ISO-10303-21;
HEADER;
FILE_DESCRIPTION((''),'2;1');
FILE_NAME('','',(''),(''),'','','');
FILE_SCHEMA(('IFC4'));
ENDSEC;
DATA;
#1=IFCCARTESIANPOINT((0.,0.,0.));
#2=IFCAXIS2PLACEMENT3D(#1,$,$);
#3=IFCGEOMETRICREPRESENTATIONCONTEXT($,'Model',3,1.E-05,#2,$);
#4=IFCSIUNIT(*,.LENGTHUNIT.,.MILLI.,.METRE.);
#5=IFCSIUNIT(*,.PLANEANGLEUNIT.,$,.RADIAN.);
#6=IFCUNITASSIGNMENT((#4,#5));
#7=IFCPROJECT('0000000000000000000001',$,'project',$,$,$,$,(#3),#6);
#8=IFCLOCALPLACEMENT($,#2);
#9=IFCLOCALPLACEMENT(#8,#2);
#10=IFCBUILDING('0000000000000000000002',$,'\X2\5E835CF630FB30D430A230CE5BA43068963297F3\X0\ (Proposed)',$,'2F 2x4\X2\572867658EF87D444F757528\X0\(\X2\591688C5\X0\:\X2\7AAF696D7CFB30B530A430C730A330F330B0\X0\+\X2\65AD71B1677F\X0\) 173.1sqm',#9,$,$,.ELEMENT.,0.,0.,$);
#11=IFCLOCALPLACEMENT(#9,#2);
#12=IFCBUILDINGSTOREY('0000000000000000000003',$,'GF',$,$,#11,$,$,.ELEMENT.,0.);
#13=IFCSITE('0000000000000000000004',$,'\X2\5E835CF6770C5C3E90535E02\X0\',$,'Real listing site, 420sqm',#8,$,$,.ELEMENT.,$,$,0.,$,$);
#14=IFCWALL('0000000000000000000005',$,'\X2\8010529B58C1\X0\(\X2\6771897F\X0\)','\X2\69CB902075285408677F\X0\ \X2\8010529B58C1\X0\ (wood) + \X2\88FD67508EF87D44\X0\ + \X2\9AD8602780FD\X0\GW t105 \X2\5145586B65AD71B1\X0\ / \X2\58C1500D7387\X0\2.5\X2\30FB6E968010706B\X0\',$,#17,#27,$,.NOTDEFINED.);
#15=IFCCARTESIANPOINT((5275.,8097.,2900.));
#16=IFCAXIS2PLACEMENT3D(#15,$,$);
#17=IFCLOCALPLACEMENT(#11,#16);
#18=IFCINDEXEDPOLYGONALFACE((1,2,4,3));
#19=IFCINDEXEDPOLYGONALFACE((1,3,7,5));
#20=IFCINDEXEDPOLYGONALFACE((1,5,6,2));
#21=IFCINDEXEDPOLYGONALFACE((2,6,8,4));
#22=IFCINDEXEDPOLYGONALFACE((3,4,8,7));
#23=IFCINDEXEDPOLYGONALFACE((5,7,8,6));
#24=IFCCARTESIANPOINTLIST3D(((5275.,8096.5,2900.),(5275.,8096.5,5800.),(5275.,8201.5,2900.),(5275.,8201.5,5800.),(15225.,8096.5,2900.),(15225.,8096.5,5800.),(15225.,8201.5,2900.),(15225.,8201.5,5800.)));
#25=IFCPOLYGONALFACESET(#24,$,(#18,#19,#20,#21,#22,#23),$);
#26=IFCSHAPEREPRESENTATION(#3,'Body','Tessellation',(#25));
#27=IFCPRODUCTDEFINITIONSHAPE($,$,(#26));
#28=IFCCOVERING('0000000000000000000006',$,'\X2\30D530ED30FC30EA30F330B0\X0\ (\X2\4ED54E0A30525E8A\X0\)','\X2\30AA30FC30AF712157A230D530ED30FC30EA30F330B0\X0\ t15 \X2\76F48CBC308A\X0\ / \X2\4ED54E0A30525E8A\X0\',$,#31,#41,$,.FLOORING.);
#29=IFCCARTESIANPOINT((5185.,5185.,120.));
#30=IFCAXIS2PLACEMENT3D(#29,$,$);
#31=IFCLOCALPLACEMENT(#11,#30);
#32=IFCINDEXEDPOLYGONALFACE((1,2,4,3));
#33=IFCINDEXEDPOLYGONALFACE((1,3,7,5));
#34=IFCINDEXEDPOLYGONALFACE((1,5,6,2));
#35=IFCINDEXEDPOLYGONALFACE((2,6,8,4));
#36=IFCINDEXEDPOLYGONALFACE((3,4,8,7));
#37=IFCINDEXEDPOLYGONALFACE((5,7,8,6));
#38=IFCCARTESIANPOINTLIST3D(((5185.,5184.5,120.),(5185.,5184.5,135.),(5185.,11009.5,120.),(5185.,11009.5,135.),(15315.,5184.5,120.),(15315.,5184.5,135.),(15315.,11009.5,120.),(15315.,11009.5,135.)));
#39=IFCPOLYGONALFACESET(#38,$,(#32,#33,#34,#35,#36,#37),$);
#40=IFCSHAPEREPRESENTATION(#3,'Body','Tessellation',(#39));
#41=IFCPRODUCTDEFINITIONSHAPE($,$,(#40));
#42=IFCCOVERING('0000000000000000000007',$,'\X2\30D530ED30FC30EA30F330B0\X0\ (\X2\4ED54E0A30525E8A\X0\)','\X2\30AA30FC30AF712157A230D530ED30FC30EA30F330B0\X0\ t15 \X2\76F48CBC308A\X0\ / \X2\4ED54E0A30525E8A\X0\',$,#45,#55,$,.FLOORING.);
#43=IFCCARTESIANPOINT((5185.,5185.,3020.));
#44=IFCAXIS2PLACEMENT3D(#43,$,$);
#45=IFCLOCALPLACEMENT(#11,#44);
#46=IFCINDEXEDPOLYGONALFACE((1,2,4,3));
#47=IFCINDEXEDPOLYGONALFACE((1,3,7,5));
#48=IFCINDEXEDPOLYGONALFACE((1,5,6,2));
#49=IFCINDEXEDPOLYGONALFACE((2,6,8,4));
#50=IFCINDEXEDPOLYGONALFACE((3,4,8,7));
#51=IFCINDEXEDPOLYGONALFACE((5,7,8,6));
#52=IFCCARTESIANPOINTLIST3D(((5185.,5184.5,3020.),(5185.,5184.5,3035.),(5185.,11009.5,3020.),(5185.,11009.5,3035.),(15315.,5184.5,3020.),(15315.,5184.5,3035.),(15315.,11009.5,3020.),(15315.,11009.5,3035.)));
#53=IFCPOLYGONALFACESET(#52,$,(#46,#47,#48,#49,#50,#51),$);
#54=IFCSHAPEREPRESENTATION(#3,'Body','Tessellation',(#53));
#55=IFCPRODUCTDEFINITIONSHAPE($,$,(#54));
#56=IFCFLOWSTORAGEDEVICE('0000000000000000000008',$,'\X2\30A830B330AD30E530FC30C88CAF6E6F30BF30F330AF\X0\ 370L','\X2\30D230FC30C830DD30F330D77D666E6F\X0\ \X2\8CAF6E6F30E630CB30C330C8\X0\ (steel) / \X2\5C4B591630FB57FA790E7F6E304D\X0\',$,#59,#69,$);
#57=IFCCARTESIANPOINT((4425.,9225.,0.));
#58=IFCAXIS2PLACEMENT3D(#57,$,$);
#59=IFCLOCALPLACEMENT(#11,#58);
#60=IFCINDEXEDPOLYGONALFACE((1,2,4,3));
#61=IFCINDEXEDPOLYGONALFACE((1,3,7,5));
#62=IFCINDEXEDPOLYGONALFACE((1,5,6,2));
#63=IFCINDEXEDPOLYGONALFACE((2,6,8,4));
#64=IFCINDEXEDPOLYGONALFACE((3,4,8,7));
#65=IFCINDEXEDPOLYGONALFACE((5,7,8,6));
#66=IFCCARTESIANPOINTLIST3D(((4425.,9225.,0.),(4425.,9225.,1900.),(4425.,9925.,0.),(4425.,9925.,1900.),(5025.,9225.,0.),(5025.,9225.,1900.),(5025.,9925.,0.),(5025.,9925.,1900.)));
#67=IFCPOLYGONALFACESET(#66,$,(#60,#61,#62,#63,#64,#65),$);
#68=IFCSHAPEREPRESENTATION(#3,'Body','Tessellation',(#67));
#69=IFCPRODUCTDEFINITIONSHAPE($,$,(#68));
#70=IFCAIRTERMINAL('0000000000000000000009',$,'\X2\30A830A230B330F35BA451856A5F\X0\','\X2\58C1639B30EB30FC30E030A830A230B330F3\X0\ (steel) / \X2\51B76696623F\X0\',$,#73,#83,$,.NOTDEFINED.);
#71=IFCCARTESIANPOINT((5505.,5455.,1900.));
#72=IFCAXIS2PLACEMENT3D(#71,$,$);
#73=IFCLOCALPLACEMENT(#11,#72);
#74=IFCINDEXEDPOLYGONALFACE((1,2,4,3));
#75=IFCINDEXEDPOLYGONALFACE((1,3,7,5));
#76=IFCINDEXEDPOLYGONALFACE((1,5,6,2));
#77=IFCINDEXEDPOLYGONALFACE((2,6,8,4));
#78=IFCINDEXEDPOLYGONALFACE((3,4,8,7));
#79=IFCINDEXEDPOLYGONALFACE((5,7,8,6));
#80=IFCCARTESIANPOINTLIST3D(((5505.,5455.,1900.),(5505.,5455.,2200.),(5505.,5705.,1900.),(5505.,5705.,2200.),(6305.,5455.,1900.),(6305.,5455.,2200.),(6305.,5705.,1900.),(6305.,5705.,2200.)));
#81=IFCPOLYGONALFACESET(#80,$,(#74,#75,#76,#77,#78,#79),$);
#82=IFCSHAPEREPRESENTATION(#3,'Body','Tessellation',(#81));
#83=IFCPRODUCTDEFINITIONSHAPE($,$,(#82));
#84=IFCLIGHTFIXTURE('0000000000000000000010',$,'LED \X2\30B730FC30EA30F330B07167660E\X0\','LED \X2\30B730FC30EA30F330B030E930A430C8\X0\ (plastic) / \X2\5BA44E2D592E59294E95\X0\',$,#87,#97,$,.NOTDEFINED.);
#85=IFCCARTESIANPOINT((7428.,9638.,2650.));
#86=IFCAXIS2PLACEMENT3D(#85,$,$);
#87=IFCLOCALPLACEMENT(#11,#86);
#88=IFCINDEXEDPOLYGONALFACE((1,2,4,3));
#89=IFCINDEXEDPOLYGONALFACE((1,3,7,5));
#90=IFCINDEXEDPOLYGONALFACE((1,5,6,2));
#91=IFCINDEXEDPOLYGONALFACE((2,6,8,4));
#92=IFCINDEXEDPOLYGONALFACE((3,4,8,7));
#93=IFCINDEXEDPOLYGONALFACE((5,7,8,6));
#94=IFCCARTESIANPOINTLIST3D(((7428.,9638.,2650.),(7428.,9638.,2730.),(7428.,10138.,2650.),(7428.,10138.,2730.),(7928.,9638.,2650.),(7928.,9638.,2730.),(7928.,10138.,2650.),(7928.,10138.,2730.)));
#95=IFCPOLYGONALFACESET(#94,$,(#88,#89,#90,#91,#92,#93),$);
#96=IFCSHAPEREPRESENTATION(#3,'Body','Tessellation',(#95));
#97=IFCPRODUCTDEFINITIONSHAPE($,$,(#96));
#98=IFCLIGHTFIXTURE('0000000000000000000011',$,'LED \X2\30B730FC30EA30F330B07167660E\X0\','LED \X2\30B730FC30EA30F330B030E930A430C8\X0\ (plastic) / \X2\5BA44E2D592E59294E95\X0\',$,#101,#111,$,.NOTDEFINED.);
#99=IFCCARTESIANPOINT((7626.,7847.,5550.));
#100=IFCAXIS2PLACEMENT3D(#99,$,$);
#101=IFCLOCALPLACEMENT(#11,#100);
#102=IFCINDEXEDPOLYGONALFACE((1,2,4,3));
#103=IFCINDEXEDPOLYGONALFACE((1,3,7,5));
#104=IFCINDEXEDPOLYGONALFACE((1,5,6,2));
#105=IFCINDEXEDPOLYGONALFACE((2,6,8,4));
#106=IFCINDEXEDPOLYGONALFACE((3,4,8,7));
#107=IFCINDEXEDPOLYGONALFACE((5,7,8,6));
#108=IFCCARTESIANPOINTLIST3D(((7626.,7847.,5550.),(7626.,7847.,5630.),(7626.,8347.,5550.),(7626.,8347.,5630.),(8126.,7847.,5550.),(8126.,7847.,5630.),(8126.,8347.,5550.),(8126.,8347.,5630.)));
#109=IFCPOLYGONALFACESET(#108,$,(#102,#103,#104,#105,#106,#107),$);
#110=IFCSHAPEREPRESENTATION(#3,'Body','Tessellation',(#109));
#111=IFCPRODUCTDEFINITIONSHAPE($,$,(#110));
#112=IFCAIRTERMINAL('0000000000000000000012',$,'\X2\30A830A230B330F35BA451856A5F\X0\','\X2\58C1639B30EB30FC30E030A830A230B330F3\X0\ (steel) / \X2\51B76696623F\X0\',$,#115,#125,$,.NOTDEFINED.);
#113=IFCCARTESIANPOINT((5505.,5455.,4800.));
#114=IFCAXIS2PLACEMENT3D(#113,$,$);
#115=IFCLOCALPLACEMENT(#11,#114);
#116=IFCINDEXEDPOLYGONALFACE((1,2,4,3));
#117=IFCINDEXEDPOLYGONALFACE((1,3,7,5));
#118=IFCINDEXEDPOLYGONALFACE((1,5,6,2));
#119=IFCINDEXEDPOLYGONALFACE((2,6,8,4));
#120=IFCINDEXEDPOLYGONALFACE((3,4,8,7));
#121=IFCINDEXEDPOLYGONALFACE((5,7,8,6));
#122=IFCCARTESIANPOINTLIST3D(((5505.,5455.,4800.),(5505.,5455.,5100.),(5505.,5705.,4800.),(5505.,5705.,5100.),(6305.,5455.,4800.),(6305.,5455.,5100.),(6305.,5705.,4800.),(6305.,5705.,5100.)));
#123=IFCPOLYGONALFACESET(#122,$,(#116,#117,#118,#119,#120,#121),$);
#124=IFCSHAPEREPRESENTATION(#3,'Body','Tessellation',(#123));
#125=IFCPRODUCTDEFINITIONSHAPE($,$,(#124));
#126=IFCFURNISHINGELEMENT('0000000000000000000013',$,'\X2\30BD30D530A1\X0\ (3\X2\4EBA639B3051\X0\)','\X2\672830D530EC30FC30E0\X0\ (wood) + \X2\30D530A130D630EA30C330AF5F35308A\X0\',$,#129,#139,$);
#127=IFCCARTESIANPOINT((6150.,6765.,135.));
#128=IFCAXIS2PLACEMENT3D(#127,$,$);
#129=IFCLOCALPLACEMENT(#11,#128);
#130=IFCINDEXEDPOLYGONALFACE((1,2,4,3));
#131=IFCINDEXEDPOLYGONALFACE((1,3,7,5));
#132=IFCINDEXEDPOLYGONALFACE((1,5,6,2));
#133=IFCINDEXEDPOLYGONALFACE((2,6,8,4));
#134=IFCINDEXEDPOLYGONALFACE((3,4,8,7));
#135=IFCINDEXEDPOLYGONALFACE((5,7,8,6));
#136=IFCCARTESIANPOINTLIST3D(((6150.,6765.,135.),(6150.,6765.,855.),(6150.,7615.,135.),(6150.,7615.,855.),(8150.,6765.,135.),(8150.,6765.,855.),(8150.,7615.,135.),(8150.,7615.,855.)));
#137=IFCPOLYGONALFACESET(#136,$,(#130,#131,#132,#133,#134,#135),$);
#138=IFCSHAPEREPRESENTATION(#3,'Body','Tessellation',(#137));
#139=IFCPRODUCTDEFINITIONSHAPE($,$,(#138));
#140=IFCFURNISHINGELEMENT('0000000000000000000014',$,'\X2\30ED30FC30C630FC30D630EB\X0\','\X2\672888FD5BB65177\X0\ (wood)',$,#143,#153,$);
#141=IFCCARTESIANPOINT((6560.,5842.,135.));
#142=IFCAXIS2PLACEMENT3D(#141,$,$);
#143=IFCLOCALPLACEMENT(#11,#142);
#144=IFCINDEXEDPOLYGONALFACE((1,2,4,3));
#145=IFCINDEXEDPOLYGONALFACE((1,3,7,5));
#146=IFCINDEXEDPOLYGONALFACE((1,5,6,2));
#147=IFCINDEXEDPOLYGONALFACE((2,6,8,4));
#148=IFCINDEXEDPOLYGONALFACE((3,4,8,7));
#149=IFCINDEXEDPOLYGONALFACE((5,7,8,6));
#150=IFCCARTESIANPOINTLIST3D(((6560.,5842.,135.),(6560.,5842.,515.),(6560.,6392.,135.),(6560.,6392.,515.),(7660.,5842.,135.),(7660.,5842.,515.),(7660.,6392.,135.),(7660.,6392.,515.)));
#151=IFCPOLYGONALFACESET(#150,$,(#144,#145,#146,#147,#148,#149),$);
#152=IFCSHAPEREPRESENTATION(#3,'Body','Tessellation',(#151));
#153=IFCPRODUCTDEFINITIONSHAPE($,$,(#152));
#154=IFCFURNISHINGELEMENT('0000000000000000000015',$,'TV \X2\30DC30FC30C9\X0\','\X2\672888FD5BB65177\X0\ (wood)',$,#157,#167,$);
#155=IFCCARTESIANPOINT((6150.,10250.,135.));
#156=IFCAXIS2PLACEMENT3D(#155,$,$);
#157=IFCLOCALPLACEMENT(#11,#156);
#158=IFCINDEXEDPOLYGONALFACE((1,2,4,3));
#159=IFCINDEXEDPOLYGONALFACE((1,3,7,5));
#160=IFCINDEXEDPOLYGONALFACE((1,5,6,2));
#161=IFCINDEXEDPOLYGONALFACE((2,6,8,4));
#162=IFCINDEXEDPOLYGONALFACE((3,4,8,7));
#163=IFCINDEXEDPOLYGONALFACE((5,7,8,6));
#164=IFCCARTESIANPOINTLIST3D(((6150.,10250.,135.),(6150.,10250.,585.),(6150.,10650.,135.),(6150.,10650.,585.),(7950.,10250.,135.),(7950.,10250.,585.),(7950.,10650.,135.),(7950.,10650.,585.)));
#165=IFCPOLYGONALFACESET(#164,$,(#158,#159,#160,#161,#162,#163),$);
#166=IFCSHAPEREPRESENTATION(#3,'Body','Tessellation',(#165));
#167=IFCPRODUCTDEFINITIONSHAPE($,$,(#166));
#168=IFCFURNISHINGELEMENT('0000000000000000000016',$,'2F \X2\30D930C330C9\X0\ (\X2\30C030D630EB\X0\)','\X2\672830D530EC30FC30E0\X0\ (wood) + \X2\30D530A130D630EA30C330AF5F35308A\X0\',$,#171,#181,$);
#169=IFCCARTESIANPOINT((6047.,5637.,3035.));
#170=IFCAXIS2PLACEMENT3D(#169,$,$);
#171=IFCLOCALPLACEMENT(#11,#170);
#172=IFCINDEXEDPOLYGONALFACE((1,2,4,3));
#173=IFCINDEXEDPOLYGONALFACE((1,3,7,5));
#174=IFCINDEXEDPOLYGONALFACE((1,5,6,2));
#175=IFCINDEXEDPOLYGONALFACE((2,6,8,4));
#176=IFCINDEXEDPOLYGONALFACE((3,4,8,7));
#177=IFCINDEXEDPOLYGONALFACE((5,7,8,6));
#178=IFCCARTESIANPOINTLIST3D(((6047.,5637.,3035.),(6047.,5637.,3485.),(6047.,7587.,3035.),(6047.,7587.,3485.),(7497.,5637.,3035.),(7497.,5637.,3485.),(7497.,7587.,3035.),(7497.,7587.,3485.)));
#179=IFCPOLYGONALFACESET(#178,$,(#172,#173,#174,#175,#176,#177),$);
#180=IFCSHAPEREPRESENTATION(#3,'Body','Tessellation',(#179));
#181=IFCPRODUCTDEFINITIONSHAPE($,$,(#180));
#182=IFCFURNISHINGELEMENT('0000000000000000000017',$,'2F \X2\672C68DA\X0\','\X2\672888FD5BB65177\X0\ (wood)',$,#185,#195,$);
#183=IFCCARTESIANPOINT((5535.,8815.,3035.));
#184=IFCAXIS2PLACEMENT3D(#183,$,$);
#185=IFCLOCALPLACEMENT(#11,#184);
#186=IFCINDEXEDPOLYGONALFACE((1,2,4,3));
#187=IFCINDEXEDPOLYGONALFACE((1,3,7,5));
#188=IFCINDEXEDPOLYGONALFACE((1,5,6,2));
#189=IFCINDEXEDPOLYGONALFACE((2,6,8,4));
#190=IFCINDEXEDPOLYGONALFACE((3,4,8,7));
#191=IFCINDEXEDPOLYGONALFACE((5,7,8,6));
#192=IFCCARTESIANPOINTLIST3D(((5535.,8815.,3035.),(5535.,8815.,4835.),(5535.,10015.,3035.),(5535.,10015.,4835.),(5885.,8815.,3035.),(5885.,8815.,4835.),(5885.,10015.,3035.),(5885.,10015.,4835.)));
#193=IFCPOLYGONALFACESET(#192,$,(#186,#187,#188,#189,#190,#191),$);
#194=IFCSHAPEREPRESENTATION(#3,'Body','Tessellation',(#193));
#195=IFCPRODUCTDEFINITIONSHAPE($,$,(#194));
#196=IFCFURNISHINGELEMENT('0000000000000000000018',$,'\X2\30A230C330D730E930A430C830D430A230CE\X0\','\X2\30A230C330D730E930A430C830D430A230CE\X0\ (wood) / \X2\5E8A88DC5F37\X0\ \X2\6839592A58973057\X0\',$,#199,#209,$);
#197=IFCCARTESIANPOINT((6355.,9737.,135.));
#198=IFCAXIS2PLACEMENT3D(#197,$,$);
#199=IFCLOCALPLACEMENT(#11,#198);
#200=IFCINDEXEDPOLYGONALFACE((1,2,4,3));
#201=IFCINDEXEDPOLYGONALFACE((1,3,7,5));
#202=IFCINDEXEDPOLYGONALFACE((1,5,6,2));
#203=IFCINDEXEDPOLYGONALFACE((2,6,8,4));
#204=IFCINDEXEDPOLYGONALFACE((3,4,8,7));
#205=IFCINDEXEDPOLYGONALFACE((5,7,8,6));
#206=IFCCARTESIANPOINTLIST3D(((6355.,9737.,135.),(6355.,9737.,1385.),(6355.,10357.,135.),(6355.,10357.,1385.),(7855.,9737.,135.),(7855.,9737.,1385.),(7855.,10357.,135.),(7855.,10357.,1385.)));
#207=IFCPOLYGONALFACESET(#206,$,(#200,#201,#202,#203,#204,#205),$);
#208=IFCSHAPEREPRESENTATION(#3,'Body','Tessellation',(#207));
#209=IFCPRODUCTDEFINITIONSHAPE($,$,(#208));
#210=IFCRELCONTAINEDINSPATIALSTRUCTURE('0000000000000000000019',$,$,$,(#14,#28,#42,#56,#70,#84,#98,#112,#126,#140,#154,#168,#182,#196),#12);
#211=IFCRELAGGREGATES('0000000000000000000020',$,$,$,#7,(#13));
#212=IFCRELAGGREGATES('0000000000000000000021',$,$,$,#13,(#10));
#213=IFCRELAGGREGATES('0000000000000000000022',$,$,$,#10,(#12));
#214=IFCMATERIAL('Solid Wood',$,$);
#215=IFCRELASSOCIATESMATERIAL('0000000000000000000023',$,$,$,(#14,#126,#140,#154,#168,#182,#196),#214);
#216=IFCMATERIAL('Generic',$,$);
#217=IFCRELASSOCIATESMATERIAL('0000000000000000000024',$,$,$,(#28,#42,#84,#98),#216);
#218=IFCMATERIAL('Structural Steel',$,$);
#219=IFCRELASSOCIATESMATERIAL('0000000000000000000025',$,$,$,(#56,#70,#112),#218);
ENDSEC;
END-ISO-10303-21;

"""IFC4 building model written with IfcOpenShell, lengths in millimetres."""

from ifc_helpers import new_model, si_unit, frame, frame_2d, origin, place, context, project, spatial, rectangle, extrude, material, element, save


model = new_model("IFC4")

# Units and contexts
model_context = context("Model", 3, precision=1e-05, world=origin())
ifc_project = project(units=[si_unit("LENGTHUNIT", "METRE", prefix="MILLI"), si_unit("PLANEANGLEUNIT", "RADIAN")], contexts=[model_context])

# Site, building, storey
site_placement = place(None, origin())
site = spatial("IfcSite", under=ifc_project, at=site_placement, Name="広島県尾道市", ObjectType="Real listing site, 420sqm", CompositionType="ELEMENT", RefElevation=0.0)
building_placement = place(site_placement, origin())
building = spatial("IfcBuilding", under=site, at=building_placement, Name="広島・ピアノ室と防音 (Proposed)", ObjectType="2F 2x4在来軸組併用(外装:窯業系サイディング+断熱板) 173.1sqm", CompositionType="ELEMENT", ElevationOfRefHeight=0.0, ElevationOfTerrain=0.0)
storey_placement = place(building_placement, origin())
storey = spatial("IfcBuildingStorey", under=building, at=storey_placement, Name="GF", CompositionType="ELEMENT", Elevation=0.0)

# Shared definitions
ifc_material_1 = material(Name="Solid Wood")

# Wall
wall_1_placement = place(storey_placement, frame((5275.0, 8097.0, 2900.0)))
element("IfcWall", 1, at=wall_1_placement, inside=storey, material=ifc_material_1, Name="耐力壁(東西)", Description="構造用合板 耐力壁 (wood) + 製材軸組 + 高性能GW t105 充填断熱 / 壁倍率2.5・準耐火", PredefinedType="NOTDEFINED", context=model_context, shape_type="SweptSolid", body=[
    extrude(rectangle(XDim=9950.0, YDim=105.0, at=frame_2d((4975.0, 52.0))), frame((5275.0, 8097.0, 2900.0)), (0.0, 0.0, 1.0), 2900.0),
])

# Coverings
ifc_material_2 = material(Name="Generic")
covering_1_placement = place(storey_placement, frame((5185.0, 5185.0, 120.0)))
element("IfcCovering", 2, at=covering_1_placement, inside=storey, material=ifc_material_2, Name="フローリング (仕上げ床)", Description="オーク無垢フローリング t15 直貼り / 仕上げ床", PredefinedType="FLOORING", context=model_context, shape_type="SweptSolid", body=[
    extrude(rectangle(XDim=10130.0, YDim=5825.0, at=frame_2d((5065.0, 2912.0))), frame((5185.0, 5185.0, 120.0)), (0.0, 0.0, 1.0), 15.0),
])
covering_2_placement = place(storey_placement, frame((5185.0, 5185.0, 3020.0)))
element("IfcCovering", 3, at=covering_2_placement, inside=storey, material=ifc_material_2, Name="フローリング (仕上げ床)", Description="オーク無垢フローリング t15 直貼り / 仕上げ床", PredefinedType="FLOORING", context=model_context, shape_type="SweptSolid", body=[
    extrude(rectangle(XDim=10130.0, YDim=5825.0, at=frame_2d((5065.0, 2912.0))), frame((5185.0, 5185.0, 3020.0)), (0.0, 0.0, 1.0), 15.0),
])

# Flow storage device
ifc_material_3 = material(Name="Structural Steel")
flow_storage_device_placement = place(storey_placement, frame((4425.0, 9225.0, 0.0)))
element("IfcFlowStorageDevice", 4, at=flow_storage_device_placement, inside=storey, material=ifc_material_3, Name="エコキュート貯湯タンク 370L", Description="ヒートポンプ給湯 貯湯ユニット (steel) / 屋外・基礎置き", context=model_context, shape_type="SweptSolid", body=[
    extrude(rectangle(XDim=600.0, YDim=700.0, at=frame_2d((300.0, 350.0))), frame((4425.0, 9225.0, 0.0)), (0.0, 0.0, 1.0), 1900.0),
])

# Air terminal
air_terminal_1_placement = place(storey_placement, frame((5505.0, 5455.0, 1900.0)))
element("IfcAirTerminal", 5, at=air_terminal_1_placement, inside=storey, material=ifc_material_3, Name="エアコン室内機", Description="壁掛ルームエアコン (steel) / 冷暖房", PredefinedType="NOTDEFINED", context=model_context, shape_type="SweptSolid", body=[
    extrude(rectangle(XDim=800.0, YDim=250.0, at=frame_2d((400.0, 125.0))), frame((5505.0, 5455.0, 1900.0)), (0.0, 0.0, 1.0), 300.0),
])

# Light fixtures
light_fixture_1_placement = place(storey_placement, frame((7428.0, 9638.0, 2650.0)))
element("IfcLightFixture", 6, at=light_fixture_1_placement, inside=storey, material=ifc_material_2, Name="LED シーリング照明", Description="LED シーリングライト (plastic) / 室中央天井", PredefinedType="NOTDEFINED", context=model_context, shape_type="SweptSolid", body=[
    extrude(rectangle(XDim=500.0, YDim=500.0, at=frame_2d((250.0, 250.0))), frame((7428.0, 9638.0, 2650.0)), (0.0, 0.0, 1.0), 80.0),
])
light_fixture_2_placement = place(storey_placement, frame((7626.0, 7847.0, 5550.0)))
element("IfcLightFixture", 7, at=light_fixture_2_placement, inside=storey, material=ifc_material_2, Name="LED シーリング照明", Description="LED シーリングライト (plastic) / 室中央天井", PredefinedType="NOTDEFINED", context=model_context, shape_type="SweptSolid", body=[
    extrude(rectangle(XDim=500.0, YDim=500.0, at=frame_2d((250.0, 250.0))), frame((7626.0, 7847.0, 5550.0)), (0.0, 0.0, 1.0), 80.0),
])

# Air terminal
air_terminal_2_placement = place(storey_placement, frame((5505.0, 5455.0, 4800.0)))
element("IfcAirTerminal", 8, at=air_terminal_2_placement, inside=storey, material=ifc_material_3, Name="エアコン室内機", Description="壁掛ルームエアコン (steel) / 冷暖房", PredefinedType="NOTDEFINED", context=model_context, shape_type="SweptSolid", body=[
    extrude(rectangle(XDim=800.0, YDim=250.0, at=frame_2d((400.0, 125.0))), frame((5505.0, 5455.0, 4800.0)), (0.0, 0.0, 1.0), 300.0),
])

# Furnishing elements
furnishing_1_placement = place(storey_placement, frame((6150.0, 6765.0, 135.0)))
element("IfcFurnishingElement", 9, at=furnishing_1_placement, inside=storey, material=ifc_material_1, Name="ソファ (3人掛け)", Description="木フレーム (wood) + ファブリック張り", context=model_context, shape_type="SweptSolid", body=[
    extrude(rectangle(XDim=2000.0, YDim=850.0, at=frame_2d((1000.0, 425.0))), frame((6150.0, 6765.0, 135.0)), (0.0, 0.0, 1.0), 720.0),
])
furnishing_2_placement = place(storey_placement, frame((6560.0, 5842.0, 135.0)))
element("IfcFurnishingElement", 10, at=furnishing_2_placement, inside=storey, material=ifc_material_1, Name="ローテーブル", Description="木製家具 (wood)", context=model_context, shape_type="SweptSolid", body=[
    extrude(rectangle(XDim=1100.0, YDim=550.0, at=frame_2d((550.0, 275.0))), frame((6560.0, 5842.0, 135.0)), (0.0, 0.0, 1.0), 380.0),
])
furnishing_3_placement = place(storey_placement, frame((6150.0, 10250.0, 135.0)))
element("IfcFurnishingElement", 11, at=furnishing_3_placement, inside=storey, material=ifc_material_1, Name="TV ボード", Description="木製家具 (wood)", context=model_context, shape_type="SweptSolid", body=[
    extrude(rectangle(XDim=1800.0, YDim=400.0, at=frame_2d((900.0, 200.0))), frame((6150.0, 10250.0, 135.0)), (0.0, 0.0, 1.0), 450.0),
])
furnishing_4_placement = place(storey_placement, frame((6047.0, 5637.0, 3035.0)))
element("IfcFurnishingElement", 12, at=furnishing_4_placement, inside=storey, material=ifc_material_1, Name="2F ベッド (ダブル)", Description="木フレーム (wood) + ファブリック張り", context=model_context, shape_type="SweptSolid", body=[
    extrude(rectangle(XDim=1450.0, YDim=1950.0, at=frame_2d((725.0, 975.0))), frame((6047.0, 5637.0, 3035.0)), (0.0, 0.0, 1.0), 450.0),
])
furnishing_5_placement = place(storey_placement, frame((5535.0, 8815.0, 3035.0)))
element("IfcFurnishingElement", 13, at=furnishing_5_placement, inside=storey, material=ifc_material_1, Name="2F 本棚", Description="木製家具 (wood)", context=model_context, shape_type="SweptSolid", body=[
    extrude(rectangle(XDim=350.0, YDim=1200.0, at=frame_2d((175.0, 600.0))), frame((5535.0, 8815.0, 3035.0)), (0.0, 0.0, 1.0), 1800.0),
])
furnishing_6_placement = place(storey_placement, frame((6355.0, 9737.0, 135.0)))
element("IfcFurnishingElement", 14, at=furnishing_6_placement, inside=storey, material=ifc_material_1, Name="アップライトピアノ", Description="アップライトピアノ (wood) / 床補強 根太増し", context=model_context, shape_type="SweptSolid", body=[
    extrude(rectangle(XDim=1500.0, YDim=620.0, at=frame_2d((750.0, 310.0))), frame((6355.0, 9737.0, 135.0)), (0.0, 0.0, 1.0), 1250.0),
])

save(model, "model.ifc")
